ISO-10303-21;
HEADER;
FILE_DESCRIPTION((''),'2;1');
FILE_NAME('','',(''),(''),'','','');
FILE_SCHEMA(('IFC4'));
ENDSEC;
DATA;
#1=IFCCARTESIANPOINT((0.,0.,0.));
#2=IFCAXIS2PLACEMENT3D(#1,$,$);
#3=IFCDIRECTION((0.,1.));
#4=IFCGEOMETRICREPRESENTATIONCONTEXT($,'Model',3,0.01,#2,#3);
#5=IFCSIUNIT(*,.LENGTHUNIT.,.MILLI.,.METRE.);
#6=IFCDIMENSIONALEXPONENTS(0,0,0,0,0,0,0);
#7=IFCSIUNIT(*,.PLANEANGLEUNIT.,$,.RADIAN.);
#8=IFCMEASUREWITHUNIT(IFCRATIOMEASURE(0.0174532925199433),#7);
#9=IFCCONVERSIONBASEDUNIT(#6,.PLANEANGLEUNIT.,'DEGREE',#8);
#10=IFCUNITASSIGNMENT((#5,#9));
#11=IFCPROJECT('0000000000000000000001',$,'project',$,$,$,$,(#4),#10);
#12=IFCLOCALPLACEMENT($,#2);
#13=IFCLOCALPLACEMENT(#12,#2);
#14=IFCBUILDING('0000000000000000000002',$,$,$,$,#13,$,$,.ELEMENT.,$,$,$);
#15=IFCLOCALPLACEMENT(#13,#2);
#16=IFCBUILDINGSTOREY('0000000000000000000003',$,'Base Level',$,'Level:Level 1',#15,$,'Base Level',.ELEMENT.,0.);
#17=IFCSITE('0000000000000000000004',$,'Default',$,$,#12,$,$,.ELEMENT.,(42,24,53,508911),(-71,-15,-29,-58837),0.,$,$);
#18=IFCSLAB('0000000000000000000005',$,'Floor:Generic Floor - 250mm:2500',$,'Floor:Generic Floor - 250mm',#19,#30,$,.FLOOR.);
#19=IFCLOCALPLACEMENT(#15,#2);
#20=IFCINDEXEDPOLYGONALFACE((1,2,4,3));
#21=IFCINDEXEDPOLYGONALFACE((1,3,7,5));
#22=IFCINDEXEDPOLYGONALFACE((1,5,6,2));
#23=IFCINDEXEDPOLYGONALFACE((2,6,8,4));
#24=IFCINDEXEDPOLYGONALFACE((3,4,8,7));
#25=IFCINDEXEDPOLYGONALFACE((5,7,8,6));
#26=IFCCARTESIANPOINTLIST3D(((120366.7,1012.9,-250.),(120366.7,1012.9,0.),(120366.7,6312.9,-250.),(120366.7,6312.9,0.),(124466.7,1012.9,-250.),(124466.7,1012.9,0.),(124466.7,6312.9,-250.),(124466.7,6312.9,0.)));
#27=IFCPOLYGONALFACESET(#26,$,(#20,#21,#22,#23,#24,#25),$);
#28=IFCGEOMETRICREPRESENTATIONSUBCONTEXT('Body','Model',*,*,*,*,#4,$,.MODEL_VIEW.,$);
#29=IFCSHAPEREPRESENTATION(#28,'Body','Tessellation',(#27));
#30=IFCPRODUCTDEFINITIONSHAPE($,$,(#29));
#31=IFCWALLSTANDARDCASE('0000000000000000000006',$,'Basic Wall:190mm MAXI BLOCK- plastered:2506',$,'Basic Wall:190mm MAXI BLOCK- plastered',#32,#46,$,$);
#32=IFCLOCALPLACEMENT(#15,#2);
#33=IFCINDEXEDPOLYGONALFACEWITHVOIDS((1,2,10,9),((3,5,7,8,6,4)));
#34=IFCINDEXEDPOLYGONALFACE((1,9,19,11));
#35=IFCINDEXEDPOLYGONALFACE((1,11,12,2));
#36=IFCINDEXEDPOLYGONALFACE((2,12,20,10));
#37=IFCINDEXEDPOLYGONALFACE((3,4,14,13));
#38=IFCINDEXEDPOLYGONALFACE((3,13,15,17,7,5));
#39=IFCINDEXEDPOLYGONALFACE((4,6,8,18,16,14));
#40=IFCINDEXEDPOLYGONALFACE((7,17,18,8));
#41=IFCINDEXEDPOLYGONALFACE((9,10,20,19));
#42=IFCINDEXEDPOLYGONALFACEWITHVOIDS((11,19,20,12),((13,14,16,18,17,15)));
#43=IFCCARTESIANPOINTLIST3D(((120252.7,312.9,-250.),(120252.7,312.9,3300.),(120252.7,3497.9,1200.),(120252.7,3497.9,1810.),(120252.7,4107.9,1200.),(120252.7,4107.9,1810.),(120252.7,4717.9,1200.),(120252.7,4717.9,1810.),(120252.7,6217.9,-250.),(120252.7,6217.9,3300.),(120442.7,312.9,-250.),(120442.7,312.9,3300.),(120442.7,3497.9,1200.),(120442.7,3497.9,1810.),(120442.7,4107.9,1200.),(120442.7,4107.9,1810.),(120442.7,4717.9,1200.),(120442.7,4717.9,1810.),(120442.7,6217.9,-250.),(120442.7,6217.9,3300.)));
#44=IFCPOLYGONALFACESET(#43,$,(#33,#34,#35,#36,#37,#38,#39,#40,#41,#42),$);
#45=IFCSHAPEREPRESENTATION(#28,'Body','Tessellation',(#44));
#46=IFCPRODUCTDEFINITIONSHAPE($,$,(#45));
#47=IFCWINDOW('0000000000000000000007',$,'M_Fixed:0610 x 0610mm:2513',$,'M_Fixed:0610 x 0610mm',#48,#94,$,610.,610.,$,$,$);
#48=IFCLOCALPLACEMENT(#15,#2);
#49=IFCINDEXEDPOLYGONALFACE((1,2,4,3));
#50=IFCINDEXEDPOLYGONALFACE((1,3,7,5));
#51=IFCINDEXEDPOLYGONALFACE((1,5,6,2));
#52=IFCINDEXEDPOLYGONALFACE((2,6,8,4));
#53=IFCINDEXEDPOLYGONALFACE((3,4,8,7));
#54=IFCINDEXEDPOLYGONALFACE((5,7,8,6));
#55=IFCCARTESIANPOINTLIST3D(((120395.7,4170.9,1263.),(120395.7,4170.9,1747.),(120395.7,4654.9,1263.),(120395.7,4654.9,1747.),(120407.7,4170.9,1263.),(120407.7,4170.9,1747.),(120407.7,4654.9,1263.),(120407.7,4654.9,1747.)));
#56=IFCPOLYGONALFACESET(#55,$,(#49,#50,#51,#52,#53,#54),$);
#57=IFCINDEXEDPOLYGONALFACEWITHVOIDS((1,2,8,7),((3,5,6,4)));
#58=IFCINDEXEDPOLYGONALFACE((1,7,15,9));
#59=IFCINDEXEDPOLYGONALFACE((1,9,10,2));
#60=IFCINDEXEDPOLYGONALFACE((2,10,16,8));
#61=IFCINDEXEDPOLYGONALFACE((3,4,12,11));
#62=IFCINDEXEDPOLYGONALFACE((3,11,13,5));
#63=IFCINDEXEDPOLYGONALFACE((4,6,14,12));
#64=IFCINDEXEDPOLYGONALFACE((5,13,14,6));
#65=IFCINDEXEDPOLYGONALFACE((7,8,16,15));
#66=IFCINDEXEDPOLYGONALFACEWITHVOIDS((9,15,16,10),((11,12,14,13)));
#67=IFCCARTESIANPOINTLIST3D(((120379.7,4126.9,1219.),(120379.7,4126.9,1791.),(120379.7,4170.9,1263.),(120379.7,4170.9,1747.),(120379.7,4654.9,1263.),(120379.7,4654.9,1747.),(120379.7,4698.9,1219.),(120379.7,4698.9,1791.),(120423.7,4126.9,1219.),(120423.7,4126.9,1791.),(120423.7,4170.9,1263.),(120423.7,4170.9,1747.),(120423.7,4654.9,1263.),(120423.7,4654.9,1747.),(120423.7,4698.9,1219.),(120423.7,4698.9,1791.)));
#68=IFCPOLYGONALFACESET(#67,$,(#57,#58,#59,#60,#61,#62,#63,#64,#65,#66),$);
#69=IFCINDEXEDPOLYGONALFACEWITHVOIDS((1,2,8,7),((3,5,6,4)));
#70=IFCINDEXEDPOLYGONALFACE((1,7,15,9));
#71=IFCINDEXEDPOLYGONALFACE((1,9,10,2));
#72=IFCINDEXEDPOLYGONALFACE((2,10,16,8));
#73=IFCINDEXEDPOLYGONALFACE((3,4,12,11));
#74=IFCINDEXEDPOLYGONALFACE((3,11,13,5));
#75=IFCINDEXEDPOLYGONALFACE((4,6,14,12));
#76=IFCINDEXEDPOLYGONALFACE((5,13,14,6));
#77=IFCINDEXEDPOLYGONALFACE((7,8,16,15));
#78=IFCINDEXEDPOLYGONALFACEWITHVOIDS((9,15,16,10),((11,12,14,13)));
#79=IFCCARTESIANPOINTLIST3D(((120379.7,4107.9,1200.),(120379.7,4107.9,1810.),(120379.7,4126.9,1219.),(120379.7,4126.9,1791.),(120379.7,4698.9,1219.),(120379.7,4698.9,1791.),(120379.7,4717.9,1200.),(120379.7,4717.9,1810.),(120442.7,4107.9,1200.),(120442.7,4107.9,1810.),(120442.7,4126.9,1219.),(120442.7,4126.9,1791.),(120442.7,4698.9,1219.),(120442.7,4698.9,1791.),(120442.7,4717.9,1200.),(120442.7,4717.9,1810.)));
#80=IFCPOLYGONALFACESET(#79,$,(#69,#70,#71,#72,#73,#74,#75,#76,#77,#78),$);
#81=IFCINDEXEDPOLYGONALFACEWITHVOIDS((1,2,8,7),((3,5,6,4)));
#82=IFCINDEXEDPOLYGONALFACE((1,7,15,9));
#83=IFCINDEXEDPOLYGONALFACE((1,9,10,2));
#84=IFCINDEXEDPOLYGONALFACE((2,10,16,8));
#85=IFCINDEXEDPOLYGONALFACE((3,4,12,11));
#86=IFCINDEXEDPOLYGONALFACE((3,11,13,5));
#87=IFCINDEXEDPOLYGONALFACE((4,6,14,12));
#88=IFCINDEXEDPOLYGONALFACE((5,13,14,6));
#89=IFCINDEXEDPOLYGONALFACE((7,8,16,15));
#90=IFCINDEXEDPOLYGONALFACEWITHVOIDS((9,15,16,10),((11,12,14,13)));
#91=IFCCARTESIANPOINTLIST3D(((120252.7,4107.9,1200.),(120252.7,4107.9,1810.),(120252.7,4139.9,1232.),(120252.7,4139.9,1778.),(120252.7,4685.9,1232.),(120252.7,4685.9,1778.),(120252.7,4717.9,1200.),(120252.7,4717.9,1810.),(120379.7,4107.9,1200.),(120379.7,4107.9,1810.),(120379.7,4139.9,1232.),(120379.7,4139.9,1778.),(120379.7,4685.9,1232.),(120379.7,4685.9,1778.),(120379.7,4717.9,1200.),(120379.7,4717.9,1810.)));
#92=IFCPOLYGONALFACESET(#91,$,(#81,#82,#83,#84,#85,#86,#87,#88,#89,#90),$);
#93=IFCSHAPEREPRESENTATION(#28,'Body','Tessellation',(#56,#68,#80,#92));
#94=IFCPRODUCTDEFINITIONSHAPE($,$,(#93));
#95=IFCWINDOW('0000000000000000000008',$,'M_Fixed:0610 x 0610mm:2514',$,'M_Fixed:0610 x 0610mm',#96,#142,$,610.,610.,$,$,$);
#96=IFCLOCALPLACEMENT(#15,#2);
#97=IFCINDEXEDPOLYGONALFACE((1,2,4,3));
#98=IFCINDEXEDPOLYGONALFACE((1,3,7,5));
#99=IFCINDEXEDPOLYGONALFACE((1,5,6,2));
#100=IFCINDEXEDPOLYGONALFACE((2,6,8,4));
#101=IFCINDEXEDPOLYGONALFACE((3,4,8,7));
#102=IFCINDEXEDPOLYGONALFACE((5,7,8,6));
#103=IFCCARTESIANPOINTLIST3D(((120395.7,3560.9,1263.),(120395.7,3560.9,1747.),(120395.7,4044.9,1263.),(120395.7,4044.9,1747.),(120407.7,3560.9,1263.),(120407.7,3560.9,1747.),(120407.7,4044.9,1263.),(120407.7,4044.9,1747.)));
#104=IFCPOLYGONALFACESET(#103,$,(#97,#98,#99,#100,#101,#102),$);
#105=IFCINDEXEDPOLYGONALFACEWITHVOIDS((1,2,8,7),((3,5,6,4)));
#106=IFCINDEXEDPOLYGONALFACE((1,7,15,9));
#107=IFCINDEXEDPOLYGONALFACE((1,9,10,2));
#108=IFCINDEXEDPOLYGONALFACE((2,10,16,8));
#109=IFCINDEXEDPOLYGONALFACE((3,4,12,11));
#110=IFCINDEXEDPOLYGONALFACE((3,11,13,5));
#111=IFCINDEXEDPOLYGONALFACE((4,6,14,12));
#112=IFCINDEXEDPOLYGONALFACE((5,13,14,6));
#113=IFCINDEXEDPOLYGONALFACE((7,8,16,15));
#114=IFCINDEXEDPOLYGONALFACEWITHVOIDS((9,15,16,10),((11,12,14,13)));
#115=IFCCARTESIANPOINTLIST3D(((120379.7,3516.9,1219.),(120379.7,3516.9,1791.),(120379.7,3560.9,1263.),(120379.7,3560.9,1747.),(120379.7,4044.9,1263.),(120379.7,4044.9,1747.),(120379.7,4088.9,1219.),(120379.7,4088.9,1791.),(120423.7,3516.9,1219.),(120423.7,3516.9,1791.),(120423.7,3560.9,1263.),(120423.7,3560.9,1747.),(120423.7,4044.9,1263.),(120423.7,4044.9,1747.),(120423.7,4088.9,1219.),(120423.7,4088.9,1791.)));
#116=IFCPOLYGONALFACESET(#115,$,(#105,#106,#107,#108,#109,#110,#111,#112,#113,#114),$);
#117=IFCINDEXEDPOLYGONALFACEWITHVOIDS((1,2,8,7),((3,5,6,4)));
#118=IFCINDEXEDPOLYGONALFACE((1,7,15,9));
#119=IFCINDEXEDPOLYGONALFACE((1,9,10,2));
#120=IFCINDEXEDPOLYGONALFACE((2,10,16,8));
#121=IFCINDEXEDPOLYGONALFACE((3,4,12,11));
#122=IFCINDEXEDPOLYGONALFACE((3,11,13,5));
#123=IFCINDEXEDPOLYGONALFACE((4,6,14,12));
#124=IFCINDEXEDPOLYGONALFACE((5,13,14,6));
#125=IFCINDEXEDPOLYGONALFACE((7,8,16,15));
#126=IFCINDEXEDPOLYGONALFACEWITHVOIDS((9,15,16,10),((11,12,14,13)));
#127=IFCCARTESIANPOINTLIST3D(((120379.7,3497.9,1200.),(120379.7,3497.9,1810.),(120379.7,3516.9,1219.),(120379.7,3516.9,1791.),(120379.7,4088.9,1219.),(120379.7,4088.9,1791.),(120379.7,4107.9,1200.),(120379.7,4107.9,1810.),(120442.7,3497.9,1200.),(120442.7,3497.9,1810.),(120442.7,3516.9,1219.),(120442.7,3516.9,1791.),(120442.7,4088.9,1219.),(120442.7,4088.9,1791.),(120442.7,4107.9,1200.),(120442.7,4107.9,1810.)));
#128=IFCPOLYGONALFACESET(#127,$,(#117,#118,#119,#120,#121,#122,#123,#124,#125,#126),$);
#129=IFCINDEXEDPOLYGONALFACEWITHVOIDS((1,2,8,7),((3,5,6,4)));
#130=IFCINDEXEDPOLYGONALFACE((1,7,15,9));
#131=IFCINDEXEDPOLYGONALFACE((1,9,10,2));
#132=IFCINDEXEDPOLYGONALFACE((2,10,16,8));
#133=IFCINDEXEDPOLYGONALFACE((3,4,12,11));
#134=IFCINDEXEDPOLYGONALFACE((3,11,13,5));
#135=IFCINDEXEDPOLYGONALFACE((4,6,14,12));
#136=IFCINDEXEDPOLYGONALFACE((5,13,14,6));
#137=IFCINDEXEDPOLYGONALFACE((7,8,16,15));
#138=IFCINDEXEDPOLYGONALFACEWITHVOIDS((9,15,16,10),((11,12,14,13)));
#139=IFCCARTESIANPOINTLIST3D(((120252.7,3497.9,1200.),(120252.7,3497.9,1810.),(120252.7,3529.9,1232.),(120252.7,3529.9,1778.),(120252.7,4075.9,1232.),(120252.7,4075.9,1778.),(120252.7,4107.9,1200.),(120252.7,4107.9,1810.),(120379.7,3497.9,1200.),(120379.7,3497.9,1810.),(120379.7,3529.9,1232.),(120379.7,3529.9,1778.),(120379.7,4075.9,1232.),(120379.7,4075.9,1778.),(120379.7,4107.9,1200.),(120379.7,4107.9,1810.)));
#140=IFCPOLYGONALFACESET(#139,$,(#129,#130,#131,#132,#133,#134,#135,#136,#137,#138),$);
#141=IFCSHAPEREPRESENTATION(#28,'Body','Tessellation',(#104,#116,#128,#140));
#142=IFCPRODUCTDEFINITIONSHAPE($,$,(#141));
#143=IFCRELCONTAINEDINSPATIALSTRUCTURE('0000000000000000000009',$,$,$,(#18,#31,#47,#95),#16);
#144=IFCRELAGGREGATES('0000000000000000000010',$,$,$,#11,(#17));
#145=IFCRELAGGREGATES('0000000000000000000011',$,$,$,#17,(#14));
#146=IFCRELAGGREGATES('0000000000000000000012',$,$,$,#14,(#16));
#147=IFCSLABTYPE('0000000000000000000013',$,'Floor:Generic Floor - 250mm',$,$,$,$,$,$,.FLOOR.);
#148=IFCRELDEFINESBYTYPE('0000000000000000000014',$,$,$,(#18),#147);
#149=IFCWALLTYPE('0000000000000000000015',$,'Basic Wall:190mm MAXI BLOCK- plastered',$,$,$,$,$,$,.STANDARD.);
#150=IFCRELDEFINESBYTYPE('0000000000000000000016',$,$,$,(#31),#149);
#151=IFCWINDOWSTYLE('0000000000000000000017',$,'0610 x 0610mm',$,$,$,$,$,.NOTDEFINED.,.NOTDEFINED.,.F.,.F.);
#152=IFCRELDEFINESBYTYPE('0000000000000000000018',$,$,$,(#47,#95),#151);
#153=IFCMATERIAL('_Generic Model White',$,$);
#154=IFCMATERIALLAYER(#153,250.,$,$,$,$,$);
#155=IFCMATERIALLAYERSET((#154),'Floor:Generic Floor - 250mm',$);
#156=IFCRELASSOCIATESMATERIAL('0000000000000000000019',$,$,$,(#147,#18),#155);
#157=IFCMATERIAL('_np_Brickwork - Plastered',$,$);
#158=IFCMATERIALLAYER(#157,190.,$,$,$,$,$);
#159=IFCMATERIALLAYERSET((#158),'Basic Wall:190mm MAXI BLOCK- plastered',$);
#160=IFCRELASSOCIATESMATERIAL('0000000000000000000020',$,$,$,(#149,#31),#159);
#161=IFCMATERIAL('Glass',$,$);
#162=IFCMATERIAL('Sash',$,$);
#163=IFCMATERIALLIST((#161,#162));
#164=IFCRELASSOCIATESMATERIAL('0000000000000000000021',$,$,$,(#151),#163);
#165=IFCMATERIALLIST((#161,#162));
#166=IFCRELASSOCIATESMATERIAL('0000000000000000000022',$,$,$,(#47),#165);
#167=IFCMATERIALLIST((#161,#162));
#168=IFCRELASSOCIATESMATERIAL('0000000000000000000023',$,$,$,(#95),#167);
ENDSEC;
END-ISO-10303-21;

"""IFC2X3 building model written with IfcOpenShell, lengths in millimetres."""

from ifc_helpers import new_model, entity, si_unit, converted_unit, direction, frame, frame_2d, origin, place, context, subcontext, project, spatial, polyline, rectangle, outline, extrude, source, transform, mapped, material, material_list, layer, layer_set, layer_usage, type_object, type_shapes, element, fill, save


model = new_model("IFC2X3")

# Units and contexts
model_context = context("Model", 3, precision=0.01, world=origin(), true_north=direction((0.0, 1.0)))
body_context = subcontext(model_context, "Body", "Model", "MODEL_VIEW")
ifc_project = project(units=[si_unit("LENGTHUNIT", "METRE", prefix="MILLI"), converted_unit("PLANEANGLEUNIT", "DEGREE", entity("IfcRatioMeasure", 0.0174532925199433), si_unit("PLANEANGLEUNIT", "RADIAN"), dimensions=[0, 0, 0, 0, 0, 0, 0])], contexts=[model_context])

# Site, building, storey
site_placement = place(None, origin())
site = spatial("IfcSite", under=ifc_project, at=site_placement, Name="Default", CompositionType="ELEMENT", RefLatitude=(42, 24, 53, 508911), RefLongitude=(-71, -15, -29, -58837), RefElevation=0.0)
building_placement = place(site_placement, origin())
building = spatial("IfcBuilding", under=site, at=building_placement, CompositionType="ELEMENT")
storey_placement = place(building_placement, origin())
storey = spatial("IfcBuildingStorey", under=building, at=storey_placement, Name="Base Level", ObjectType="Level:Level 1", LongName="Base Level", CompositionType="ELEMENT", Elevation=0.0)

# Slab
ifc_material_1 = material(Name="_Generic Model White")
ifc_layer_1 = layer(ifc_material_1, 250.0)
ifc_layer_set_1 = layer_set([ifc_layer_1], Name="Floor:Generic Floor - 250mm")
ifc_layer_usage_1 = layer_usage(ifc_layer_set_1, "AXIS3", "POSITIVE", 0.0)
slab_type = type_object("IfcSlabType", Name="Floor:Generic Floor - 250mm", PredefinedType="FLOOR", material=ifc_layer_set_1)
slab_placement = place(building_placement, origin())
element("IfcSlab", 1, at=slab_placement, inside=storey, type_object=slab_type, material=ifc_layer_usage_1, Name="Floor:Generic Floor - 250mm:2500", ObjectType="Floor:Generic Floor - 250mm", PredefinedType="FLOOR", context=body_context, shape_type="SweptSolid", body=[
    extrude(rectangle(XDim=5300.0, YDim=4100.0, at=frame_2d((0.0, 0.0), x_axis=(1.0, 0.0))), frame((122416.7, 3662.9, 0.0), z_axis=(0.0, 0.0, -1.0), x_axis=(0.0, 1.0, 0.0)), (0.0, 0.0, 1.0), 250.0),
])

# Wall, openings, windows
ifc_material_2 = material(Name="_np_Brickwork - Plastered")
ifc_layer_2 = layer(ifc_material_2, 190.0)
ifc_layer_set_2 = layer_set([ifc_layer_2], Name="Basic Wall:190mm MAXI BLOCK- plastered")
ifc_layer_usage_2 = layer_usage(ifc_layer_set_2, "AXIS2", "NEGATIVE", 95.0)
wall_type = type_object("IfcWallType", Name="Basic Wall:190mm MAXI BLOCK- plastered", PredefinedType="STANDARD", material=ifc_layer_set_2)
wall_placement = place(building_placement, frame((120347.7, 312.9, -250.0), z_axis=(0.0, 0.0, 1.0), x_axis=(0.0, 1.0, 0.0)))
wall = element("IfcWallStandardCase", 2, at=wall_placement, inside=storey, type_object=wall_type, material=ifc_layer_usage_2, Name="Basic Wall:190mm MAXI BLOCK- plastered:2506", ObjectType="Basic Wall:190mm MAXI BLOCK- plastered", context=body_context, shape_type="SweptSolid", body=[
    extrude(rectangle(XDim=5905.0, YDim=190.0, at=frame_2d((2952.5, 0.0), x_axis=(-1.0, 0.0))), origin(), (0.0, 0.0, 1.0), 3550.0),
])
opening_1_placement = place(wall_placement, frame((4405.0, 95.0, 1450.0)))
opening_1 = element("IfcOpeningElement", 3, at=opening_1_placement, cuts=wall, ObjectType="Opening", context=body_context, shape_type="SweptSolid", body=[
    extrude(rectangle(XDim=610.0, YDim=610.0, at=frame_2d((305.0, 305.0), x_axis=(1.0, 0.0))), frame((0.0, 0.0, 0.0), z_axis=(0.0, -1.0, 0.0), x_axis=(0.0, 0.0, 1.0)), (0.0, 0.0, 1.0), 190.0),
])
opening_2_placement = place(wall_placement, frame((3795.0, 95.0, 1450.0)))
opening_2 = element("IfcOpeningElement", 4, at=opening_2_placement, cuts=wall, ObjectType="Opening", context=body_context, shape_type="SweptSolid", body=[
    extrude(rectangle(XDim=610.0, YDim=610.0, at=frame_2d((305.0, 305.0), x_axis=(1.0, 0.0))), frame((0.0, 0.0, 0.0), z_axis=(0.0, -1.0, 0.0), x_axis=(0.0, 0.0, 1.0)), (0.0, 0.0, 1.0), 190.0),
])
ifc_material_3 = material(Name="Glass")
ifc_material_4 = material(Name="Sash")
ifc_material_list_1 = material_list([ifc_material_3, ifc_material_4])
ifc_material_list_2 = material_list([ifc_material_3, ifc_material_4])
window_style = type_object("IfcWindowStyle", Name="0610 x 0610mm", ConstructionType="NOTDEFINED", OperationType="NOTDEFINED", ParameterTakesPrecedence=False, Sizeable=False, material=ifc_material_list_2)
shared_shape_1 = source(origin(), body_context, "Body", "SweptSolid", [
    extrude(rectangle(XDim=12.0, YDim=484.0, at=frame_2d((0.0, 0.0), x_axis=(1.0, 0.0))), frame((305.0, 149.0, 63.0), z_axis=(0.0, 0.0, 1.0), x_axis=(0.0, -1.0, 0.0)), (0.0, 0.0, 1.0), 484.0),
    extrude(outline(polyline([(-286.0, -286.0), (286.0, -286.0), (286.0, 286.0), (-286.0, 286.0), (-286.0, -286.0)]), holes=[polyline([(-242.0, -242.0), (-242.0, 242.0), (242.0, 242.0), (242.0, -242.0), (-242.0, -242.0)])]), frame((305.0, 127.0, 305.0), z_axis=(0.0, 1.0, 0.0), x_axis=(1.0, 0.0, 0.0)), (0.0, 0.0, 1.0), 44.0),
    extrude(outline(polyline([(-305.0, -305.0), (305.0, -305.0), (305.0, 305.0), (-305.0, 305.0), (-305.0, -305.0)]), holes=[polyline([(-286.0, -286.0), (-286.0, 286.0), (286.0, 286.0), (286.0, -286.0), (-286.0, -286.0)])]), frame((305.0, 127.0, 305.0), z_axis=(0.0, 1.0, 0.0), x_axis=(1.0, 0.0, 0.0)), (0.0, 0.0, 1.0), 63.0),
    extrude(outline(polyline([(-305.0, -305.0), (305.0, -305.0), (305.0, 305.0), (-305.0, 305.0), (-305.0, -305.0)]), holes=[polyline([(-273.0, -273.0), (-273.0, 273.0), (273.0, 273.0), (273.0, -273.0), (-273.0, -273.0)])]), frame((305.0, 0.0, 305.0), z_axis=(0.0, 1.0, 0.0), x_axis=(1.0, 0.0, 0.0)), (0.0, 0.0, 1.0), 127.0),
])
type_shapes(window_style, [shared_shape_1])
window_1_placement = place(opening_1_placement, frame((0.0, 0.0, 0.0), z_axis=(0.0, 0.0, 1.0), x_axis=(-1.0, 0.0, 0.0)))
window_1 = element("IfcWindow", 5, at=window_1_placement, inside=storey, type_object=window_style, material=ifc_material_list_1, Name="M_Fixed:0610 x 0610mm:2513", ObjectType="M_Fixed:0610 x 0610mm", OverallHeight=610.0, OverallWidth=610.0, context=body_context, shape_type="MappedRepresentation", body=[
    mapped(shared_shape_1, transform((0.0, 0.0, 0.0), scale=1.0)),
])
fill(opening_1, window_1)
ifc_material_list_3 = material_list([ifc_material_3, ifc_material_4])
window_2_placement = place(opening_2_placement, frame((0.0, 0.0, 0.0), z_axis=(0.0, 0.0, 1.0), x_axis=(-1.0, 0.0, 0.0)))
window_2 = element("IfcWindow", 6, at=window_2_placement, inside=storey, type_object=window_style, material=ifc_material_list_3, Name="M_Fixed:0610 x 0610mm:2514", ObjectType="M_Fixed:0610 x 0610mm", OverallHeight=610.0, OverallWidth=610.0, context=body_context, shape_type="MappedRepresentation", body=[
    mapped(shared_shape_1, transform((0.0, 0.0, 0.0), scale=1.0)),
])
fill(opening_2, window_2)

save(model, "model.ifc")
